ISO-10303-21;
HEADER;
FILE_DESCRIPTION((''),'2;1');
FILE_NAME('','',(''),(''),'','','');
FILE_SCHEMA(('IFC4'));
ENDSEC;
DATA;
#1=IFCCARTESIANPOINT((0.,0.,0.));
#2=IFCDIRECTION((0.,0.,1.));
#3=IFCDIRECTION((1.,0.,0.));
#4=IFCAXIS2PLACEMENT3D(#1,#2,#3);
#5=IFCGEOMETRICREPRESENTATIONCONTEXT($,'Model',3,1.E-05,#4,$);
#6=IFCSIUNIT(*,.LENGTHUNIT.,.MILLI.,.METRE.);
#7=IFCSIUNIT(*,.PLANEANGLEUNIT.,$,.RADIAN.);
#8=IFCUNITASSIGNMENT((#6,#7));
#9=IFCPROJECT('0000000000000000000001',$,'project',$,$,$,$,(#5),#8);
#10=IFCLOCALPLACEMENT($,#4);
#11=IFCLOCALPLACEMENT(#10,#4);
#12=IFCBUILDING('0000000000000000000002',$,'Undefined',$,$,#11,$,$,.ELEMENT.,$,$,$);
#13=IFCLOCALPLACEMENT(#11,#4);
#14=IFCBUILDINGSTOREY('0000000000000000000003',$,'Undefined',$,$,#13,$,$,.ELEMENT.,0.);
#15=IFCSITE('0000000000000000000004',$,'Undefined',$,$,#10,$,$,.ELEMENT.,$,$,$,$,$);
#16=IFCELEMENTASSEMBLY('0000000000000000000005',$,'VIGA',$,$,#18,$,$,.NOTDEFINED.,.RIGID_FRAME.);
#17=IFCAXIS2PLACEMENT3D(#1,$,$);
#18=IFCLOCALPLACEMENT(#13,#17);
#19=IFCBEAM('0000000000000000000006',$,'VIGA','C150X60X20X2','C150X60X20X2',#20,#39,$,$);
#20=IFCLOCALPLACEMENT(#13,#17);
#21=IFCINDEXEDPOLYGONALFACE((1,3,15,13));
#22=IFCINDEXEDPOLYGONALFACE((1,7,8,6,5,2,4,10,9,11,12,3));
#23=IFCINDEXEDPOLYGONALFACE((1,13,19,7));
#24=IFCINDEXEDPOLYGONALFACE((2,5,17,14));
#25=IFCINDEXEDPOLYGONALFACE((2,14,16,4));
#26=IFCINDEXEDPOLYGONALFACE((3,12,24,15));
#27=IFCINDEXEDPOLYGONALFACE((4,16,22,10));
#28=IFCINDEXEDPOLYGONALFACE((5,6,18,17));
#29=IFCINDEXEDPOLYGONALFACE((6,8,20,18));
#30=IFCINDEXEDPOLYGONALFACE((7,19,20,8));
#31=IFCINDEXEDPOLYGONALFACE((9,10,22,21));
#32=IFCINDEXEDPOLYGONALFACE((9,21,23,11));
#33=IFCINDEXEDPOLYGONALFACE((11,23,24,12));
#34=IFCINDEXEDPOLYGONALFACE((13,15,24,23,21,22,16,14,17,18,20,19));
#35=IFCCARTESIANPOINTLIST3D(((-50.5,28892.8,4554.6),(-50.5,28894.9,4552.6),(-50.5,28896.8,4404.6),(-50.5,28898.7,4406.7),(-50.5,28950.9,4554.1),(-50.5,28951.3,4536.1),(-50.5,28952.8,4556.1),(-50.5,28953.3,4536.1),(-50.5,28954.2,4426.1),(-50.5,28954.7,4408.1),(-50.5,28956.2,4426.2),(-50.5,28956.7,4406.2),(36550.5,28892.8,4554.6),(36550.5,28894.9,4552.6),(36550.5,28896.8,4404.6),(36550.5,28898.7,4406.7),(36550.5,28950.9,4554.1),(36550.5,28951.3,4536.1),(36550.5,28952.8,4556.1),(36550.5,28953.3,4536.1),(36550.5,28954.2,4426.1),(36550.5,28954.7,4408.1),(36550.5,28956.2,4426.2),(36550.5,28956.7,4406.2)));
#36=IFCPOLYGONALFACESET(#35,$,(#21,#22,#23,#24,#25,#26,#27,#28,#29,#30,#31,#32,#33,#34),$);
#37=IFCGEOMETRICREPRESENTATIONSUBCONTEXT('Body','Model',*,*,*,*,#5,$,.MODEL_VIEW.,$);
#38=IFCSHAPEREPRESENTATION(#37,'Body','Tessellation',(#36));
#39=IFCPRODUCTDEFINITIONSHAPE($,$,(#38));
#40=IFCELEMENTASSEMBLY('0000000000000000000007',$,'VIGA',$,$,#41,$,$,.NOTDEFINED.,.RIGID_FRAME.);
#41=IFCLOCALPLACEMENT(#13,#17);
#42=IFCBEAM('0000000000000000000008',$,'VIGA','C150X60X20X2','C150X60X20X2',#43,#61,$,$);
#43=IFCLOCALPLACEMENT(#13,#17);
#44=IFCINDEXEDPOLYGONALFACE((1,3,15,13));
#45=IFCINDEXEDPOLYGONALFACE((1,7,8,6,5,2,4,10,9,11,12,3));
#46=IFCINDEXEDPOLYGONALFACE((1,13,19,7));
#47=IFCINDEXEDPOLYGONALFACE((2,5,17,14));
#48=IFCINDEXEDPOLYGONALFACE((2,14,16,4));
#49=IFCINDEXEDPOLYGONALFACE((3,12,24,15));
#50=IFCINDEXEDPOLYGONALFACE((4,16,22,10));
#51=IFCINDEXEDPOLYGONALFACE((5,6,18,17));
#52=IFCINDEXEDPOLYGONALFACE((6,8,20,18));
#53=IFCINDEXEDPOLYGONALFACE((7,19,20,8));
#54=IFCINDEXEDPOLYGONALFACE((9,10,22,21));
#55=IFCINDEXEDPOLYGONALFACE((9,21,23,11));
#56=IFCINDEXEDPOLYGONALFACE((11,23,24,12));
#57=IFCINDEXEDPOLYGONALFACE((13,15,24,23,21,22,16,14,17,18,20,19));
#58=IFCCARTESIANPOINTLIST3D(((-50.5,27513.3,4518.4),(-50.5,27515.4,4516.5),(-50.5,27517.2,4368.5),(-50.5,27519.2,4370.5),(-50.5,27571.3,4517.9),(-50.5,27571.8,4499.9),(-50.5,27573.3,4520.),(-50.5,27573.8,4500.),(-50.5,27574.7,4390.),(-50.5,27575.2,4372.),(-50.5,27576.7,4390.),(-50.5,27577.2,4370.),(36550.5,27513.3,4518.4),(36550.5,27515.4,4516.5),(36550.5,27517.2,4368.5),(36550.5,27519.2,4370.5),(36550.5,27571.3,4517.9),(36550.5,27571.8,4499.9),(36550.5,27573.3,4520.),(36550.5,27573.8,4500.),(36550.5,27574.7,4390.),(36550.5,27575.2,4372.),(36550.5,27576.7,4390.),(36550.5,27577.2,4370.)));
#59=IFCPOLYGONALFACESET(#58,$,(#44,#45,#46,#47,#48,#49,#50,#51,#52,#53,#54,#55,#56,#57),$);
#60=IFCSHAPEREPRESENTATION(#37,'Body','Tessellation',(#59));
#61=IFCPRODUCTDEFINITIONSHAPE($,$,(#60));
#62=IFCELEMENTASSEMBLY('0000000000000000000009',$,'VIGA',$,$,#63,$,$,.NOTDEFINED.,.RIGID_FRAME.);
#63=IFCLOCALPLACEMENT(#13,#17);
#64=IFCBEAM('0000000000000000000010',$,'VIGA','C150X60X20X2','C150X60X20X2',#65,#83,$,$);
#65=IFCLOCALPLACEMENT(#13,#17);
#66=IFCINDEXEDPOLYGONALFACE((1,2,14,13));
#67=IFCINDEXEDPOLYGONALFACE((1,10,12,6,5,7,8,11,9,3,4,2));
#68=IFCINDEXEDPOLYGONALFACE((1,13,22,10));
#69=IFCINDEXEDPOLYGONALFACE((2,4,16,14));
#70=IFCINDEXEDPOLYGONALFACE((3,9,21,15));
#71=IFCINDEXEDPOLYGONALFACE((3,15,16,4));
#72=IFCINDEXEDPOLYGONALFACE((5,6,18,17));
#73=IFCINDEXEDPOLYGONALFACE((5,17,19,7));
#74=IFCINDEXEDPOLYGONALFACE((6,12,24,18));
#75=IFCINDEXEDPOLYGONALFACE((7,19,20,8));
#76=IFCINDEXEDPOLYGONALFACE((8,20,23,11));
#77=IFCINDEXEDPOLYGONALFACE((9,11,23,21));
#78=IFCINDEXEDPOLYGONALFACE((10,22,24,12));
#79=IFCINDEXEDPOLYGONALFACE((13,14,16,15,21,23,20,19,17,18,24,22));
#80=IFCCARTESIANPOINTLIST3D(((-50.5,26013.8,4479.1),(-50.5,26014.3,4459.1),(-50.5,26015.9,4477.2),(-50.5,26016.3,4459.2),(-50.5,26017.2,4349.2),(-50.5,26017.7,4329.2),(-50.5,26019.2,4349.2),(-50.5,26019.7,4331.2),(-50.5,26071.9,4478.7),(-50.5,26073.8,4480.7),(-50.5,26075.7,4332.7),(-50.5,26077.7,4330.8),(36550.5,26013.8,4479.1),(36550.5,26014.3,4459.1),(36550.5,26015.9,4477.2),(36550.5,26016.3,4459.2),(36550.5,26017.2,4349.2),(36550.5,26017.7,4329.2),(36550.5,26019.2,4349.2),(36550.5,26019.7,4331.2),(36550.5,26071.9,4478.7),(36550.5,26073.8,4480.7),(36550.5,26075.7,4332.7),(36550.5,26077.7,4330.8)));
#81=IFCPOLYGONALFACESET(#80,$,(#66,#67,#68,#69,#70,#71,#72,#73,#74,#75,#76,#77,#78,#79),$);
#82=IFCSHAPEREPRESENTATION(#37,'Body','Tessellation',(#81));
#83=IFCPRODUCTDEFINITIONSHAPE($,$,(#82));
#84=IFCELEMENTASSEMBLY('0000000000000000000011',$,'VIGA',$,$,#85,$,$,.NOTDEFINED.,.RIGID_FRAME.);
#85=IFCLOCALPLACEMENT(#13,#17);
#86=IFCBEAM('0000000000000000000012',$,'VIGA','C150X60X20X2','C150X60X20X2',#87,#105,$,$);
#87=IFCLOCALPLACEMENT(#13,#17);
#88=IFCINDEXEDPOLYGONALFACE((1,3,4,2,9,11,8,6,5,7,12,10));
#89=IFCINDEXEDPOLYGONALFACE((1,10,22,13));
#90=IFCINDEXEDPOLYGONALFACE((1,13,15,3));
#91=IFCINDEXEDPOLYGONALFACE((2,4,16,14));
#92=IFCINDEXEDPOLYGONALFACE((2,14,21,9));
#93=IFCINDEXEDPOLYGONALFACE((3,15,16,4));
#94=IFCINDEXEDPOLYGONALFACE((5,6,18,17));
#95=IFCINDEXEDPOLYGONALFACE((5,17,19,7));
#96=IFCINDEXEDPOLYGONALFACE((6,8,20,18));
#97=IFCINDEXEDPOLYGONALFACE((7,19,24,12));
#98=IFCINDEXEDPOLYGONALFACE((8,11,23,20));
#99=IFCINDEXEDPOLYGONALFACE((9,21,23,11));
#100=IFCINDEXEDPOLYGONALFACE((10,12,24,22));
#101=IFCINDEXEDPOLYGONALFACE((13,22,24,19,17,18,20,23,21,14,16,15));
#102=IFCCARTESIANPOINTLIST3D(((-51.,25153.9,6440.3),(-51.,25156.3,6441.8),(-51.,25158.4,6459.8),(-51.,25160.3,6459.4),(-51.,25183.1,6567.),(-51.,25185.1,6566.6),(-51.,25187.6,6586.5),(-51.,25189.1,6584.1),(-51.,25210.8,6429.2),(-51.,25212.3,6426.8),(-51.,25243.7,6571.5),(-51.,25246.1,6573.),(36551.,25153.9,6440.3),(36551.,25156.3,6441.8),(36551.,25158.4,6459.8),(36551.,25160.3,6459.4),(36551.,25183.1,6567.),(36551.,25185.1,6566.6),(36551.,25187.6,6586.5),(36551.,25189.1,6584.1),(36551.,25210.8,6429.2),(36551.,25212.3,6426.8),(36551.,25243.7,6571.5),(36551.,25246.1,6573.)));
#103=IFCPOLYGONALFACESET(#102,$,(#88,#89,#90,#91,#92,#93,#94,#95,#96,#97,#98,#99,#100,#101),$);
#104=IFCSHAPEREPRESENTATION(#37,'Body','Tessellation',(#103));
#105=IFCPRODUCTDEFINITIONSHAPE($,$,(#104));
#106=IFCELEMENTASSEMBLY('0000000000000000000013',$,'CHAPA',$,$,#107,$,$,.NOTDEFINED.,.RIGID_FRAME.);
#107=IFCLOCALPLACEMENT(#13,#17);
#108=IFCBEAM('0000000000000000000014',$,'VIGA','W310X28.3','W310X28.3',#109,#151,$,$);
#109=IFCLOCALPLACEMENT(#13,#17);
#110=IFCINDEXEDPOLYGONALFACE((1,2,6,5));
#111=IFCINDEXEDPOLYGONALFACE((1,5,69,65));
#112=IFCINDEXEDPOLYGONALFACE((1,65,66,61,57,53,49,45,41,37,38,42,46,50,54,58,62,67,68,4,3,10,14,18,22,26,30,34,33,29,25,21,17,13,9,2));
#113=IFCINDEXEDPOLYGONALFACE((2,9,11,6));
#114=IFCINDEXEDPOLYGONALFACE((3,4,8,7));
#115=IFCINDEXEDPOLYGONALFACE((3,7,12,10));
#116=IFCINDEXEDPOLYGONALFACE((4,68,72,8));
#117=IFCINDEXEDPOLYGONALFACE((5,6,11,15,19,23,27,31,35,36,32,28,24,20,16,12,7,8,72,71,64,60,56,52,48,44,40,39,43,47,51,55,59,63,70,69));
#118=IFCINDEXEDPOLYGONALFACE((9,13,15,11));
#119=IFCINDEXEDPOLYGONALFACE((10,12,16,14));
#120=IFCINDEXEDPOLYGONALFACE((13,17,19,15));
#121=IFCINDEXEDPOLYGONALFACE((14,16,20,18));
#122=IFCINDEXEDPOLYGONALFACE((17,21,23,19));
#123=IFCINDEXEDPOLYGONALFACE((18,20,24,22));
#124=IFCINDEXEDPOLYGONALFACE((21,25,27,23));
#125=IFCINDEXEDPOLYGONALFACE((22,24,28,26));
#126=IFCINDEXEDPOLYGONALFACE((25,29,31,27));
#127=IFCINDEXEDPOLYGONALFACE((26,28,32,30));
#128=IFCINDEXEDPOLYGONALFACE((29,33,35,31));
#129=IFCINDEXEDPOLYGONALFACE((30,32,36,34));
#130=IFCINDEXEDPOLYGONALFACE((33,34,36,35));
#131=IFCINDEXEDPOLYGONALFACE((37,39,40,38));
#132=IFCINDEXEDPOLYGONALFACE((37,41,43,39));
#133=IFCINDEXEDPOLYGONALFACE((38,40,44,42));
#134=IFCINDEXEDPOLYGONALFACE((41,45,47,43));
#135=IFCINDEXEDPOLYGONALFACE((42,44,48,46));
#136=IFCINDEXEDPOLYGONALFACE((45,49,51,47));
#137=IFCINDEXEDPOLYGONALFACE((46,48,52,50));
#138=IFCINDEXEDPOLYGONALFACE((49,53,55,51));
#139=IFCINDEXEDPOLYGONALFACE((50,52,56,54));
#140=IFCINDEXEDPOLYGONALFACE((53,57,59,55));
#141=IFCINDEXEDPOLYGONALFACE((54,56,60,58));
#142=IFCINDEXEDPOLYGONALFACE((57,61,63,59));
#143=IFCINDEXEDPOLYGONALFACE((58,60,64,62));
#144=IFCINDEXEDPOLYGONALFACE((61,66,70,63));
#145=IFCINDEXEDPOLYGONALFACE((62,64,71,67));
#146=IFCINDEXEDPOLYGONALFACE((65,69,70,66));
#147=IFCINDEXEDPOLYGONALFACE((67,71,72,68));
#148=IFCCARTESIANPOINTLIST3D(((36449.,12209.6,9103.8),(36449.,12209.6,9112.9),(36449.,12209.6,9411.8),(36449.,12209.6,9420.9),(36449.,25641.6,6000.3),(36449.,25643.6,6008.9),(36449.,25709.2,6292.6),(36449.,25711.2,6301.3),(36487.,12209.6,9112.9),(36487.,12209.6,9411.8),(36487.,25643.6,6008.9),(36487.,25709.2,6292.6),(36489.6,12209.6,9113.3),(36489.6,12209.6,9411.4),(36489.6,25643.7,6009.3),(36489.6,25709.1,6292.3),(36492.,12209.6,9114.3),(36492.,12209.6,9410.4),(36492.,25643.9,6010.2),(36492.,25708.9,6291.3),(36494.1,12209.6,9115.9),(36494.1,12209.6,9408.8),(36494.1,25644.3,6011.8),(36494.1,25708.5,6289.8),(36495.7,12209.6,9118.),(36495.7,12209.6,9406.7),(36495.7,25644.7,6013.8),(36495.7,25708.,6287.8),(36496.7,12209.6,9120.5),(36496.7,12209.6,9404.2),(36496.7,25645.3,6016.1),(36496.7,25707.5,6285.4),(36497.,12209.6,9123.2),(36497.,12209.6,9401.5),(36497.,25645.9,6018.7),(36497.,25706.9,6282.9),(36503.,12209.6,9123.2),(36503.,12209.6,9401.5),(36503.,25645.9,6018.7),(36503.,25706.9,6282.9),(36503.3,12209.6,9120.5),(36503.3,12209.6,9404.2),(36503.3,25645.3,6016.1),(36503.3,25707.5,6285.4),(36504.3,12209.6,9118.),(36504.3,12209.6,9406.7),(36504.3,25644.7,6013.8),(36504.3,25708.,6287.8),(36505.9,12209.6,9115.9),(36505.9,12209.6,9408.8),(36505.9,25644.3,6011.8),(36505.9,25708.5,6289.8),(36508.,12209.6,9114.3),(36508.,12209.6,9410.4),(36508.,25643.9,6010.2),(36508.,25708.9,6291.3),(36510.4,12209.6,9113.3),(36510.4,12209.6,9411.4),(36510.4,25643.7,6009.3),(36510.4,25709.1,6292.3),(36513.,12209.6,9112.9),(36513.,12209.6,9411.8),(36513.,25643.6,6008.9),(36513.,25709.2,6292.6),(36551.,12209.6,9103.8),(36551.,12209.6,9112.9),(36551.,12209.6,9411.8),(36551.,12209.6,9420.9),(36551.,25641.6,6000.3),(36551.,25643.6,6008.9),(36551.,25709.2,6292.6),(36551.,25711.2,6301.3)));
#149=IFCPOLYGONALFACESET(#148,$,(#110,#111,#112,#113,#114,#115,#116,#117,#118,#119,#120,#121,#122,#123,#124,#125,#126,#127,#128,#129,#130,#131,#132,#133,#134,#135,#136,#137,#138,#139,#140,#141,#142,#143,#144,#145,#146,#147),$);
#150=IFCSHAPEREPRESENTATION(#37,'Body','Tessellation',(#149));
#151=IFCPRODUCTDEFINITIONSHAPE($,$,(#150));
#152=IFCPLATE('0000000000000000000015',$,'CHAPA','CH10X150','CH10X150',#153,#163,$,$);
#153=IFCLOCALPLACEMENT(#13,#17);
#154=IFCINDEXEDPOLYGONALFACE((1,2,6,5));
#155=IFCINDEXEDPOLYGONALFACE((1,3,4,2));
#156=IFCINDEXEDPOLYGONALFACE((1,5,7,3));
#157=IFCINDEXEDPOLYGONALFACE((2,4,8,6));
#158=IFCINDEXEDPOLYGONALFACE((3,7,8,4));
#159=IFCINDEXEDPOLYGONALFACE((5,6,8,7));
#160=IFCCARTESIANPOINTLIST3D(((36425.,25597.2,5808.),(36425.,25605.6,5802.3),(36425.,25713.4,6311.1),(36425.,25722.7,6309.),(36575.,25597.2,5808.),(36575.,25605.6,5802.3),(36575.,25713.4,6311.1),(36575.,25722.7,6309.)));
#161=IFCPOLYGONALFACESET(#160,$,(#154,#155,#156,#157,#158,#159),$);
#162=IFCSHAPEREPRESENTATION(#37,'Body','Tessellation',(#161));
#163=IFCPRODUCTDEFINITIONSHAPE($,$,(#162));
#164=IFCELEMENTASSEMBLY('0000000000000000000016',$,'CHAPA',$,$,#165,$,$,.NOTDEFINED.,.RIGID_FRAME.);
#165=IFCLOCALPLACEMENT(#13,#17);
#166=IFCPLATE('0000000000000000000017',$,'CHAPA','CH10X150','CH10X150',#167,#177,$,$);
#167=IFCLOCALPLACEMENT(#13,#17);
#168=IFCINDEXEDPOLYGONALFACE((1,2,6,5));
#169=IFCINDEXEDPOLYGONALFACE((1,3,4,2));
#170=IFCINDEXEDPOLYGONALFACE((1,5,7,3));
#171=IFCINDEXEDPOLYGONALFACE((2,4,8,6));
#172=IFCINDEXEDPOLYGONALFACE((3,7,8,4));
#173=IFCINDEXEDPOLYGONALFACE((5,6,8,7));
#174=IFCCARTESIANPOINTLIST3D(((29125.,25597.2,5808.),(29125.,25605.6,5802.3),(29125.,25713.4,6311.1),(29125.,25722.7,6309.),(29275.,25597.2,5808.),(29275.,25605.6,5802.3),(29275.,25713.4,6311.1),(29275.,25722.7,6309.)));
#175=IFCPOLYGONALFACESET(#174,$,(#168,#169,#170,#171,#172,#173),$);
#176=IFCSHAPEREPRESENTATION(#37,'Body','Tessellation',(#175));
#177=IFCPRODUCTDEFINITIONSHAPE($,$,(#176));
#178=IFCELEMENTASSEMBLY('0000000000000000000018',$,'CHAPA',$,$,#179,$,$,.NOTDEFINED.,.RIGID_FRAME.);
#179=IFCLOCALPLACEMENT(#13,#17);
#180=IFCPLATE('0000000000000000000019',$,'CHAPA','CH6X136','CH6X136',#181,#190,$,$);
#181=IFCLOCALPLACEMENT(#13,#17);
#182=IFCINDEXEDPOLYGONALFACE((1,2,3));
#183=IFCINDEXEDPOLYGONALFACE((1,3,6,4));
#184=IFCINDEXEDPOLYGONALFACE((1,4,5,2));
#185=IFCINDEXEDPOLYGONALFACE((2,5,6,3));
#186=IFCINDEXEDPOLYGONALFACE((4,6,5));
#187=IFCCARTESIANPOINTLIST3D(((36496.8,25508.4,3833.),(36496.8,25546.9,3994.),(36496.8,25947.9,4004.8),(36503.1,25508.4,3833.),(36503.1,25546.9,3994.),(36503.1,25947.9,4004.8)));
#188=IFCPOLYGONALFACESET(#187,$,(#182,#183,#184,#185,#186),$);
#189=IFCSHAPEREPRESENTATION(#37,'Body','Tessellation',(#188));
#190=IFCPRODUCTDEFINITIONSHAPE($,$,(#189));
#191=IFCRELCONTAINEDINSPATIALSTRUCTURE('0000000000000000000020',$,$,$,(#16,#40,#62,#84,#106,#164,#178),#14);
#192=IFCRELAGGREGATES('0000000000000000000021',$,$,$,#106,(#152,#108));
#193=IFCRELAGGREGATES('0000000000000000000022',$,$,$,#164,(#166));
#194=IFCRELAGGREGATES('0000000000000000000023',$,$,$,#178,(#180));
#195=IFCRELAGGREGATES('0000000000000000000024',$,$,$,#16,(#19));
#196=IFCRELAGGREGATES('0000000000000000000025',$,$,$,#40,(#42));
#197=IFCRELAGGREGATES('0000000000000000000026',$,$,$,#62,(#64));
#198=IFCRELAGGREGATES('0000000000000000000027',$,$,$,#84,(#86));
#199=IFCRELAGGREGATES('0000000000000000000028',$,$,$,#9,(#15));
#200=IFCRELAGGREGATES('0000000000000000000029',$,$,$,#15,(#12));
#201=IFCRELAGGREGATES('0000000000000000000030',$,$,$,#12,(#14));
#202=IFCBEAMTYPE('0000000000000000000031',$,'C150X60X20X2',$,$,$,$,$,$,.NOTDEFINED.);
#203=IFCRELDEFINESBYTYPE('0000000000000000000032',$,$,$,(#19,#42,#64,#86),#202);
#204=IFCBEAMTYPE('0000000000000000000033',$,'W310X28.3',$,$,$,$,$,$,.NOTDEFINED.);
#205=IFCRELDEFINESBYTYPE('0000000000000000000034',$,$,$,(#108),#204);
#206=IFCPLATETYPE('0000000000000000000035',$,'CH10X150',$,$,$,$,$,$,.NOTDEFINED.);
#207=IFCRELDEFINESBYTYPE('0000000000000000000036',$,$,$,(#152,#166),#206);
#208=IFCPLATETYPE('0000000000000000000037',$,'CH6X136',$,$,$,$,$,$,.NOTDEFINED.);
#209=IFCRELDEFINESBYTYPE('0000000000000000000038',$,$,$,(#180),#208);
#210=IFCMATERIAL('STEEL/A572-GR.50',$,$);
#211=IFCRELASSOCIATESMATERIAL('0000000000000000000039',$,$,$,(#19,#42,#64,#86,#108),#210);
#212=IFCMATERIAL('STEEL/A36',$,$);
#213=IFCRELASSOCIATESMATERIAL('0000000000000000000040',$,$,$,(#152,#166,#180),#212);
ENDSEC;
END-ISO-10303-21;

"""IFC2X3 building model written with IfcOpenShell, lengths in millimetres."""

from ifc_helpers import new_model, si_unit, frame, origin_with_axes, origin_2d_with_axis, place, context, subcontext, project, spatial, polyline, i_section, c_section, outline, extrude, clip, halfspace, material, type_object, element, aggregate, save


model = new_model("IFC2X3")

# Units and contexts
model_context = context("Model", 3, precision=1e-05, world=origin_with_axes())
body_context = subcontext(model_context, "Body", "Model", "MODEL_VIEW")
ifc_project = project(units=[si_unit("LENGTHUNIT", "METRE", prefix="MILLI"), si_unit("PLANEANGLEUNIT", "RADIAN")], contexts=[model_context])

# Site, building, storey
site_placement = place(None, origin_with_axes())
site = spatial("IfcSite", under=ifc_project, at=site_placement, Name="Undefined", CompositionType="ELEMENT")
building_placement = place(site_placement, origin_with_axes())
building = spatial("IfcBuilding", under=site, at=building_placement, Name="Undefined", CompositionType="ELEMENT")
storey_placement = place(building_placement, origin_with_axes())
storey = spatial("IfcBuildingStorey", under=building, at=storey_placement, Name="Undefined", CompositionType="ELEMENT", Elevation=0.0)

# Element assemblies, beams
ifc_material_1 = material(Name="STEEL/A36")
assembly_1_placement = place(storey_placement, origin_with_axes())
assembly_1 = element("IfcElementAssembly", 1, at=assembly_1_placement, inside=storey, Name="VIGA", AssemblyPlace="NOTDEFINED", PredefinedType="RIGID_FRAME")
ifc_material_2 = material(Name="STEEL/A572-GR.50")
beam_type_1 = type_object("IfcBeamType", Name="C150X60X20X2", PredefinedType="NOTDEFINED")
beam_1_placement = place(assembly_1_placement, frame((36550.5, 28924.8, 4480.4), z_axis=(0.0, -0.026187, 0.999657), x_axis=(-1.0, 0.0, 0.0)))
beam_1 = element("IfcBeam", 2, at=beam_1_placement, type_object=beam_type_1, material=ifc_material_2, Name="VIGA", Description="C150X60X20X2", ObjectType="C150X60X20X2", context=body_context, shape_type="SweptSolid", body=[
    extrude(c_section(Depth=150.0, Width=60.0, WallThickness=2.0, Girth=20.0, at=origin_2d_with_axis()), frame((36601.0, 0.0, 0.0), z_axis=(-1.0, 0.0, 0.0), x_axis=(0.0, -1.0, 0.0)), (0.0, 0.0, 1.0), 36601.0),
])
assembly_2_placement = place(storey_placement, origin_with_axes())
assembly_2 = element("IfcElementAssembly", 3, at=assembly_2_placement, inside=storey, Name="VIGA", AssemblyPlace="NOTDEFINED", PredefinedType="RIGID_FRAME")
beam_2_placement = place(assembly_2_placement, frame((36550.5, 27545.3, 4444.2), z_axis=(0.0, -0.026187, 0.999657), x_axis=(-1.0, 0.0, 0.0)))
beam_2 = element("IfcBeam", 4, at=beam_2_placement, type_object=beam_type_1, material=ifc_material_2, Name="VIGA", Description="C150X60X20X2", ObjectType="C150X60X20X2", context=body_context, shape_type="SweptSolid", body=[
    extrude(c_section(Depth=150.0, Width=60.0, WallThickness=2.0, Girth=20.0, at=origin_2d_with_axis()), frame((36601.0, 0.0, 0.0), z_axis=(-1.0, 0.0, 0.0), x_axis=(0.0, -1.0, 0.0)), (0.0, 0.0, 1.0), 36601.0),
])
assembly_3_placement = place(storey_placement, origin_with_axes())
assembly_3 = element("IfcElementAssembly", 5, at=assembly_3_placement, inside=storey, Name="VIGA", AssemblyPlace="NOTDEFINED", PredefinedType="RIGID_FRAME")
beam_3_placement = place(assembly_3_placement, frame((36550.5, 26045.8, 4404.9), z_axis=(0.0, 0.026187, -0.999657), x_axis=(-1.0, 0.0, 0.0)))
beam_3 = element("IfcBeam", 6, at=beam_3_placement, type_object=beam_type_1, material=ifc_material_2, Name="VIGA", Description="C150X60X20X2", ObjectType="C150X60X20X2", context=body_context, shape_type="SweptSolid", body=[
    extrude(c_section(Depth=150.0, Width=60.0, WallThickness=2.0, Girth=20.0, at=origin_2d_with_axis()), frame((36601.0, 0.0, 0.0), z_axis=(-1.0, 0.0, 0.0), x_axis=(0.0, -1.0, 0.0)), (0.0, 0.0, 1.0), 36601.0),
])
assembly_4_placement = place(storey_placement, origin_with_axes())
assembly_4 = element("IfcElementAssembly", 7, at=assembly_4_placement, inside=storey, Name="VIGA", AssemblyPlace="NOTDEFINED", PredefinedType="RIGID_FRAME")
beam_4_placement = place(assembly_4_placement, frame((36551.0, 25200.0, 6506.7), z_axis=(0.0, -0.225124, -0.97433), x_axis=(-1.0, 0.0, 0.0)))
beam_4 = element("IfcBeam", 8, at=beam_4_placement, type_object=beam_type_1, material=ifc_material_2, Name="VIGA", Description="C150X60X20X2", ObjectType="C150X60X20X2", context=body_context, shape_type="SweptSolid", body=[
    extrude(c_section(Depth=150.0, Width=60.0, WallThickness=2.0, Girth=20.0, at=origin_2d_with_axis()), frame((36602.0, 0.0, 0.0), z_axis=(-1.0, 0.0, 0.0), x_axis=(0.0, -1.0, 0.0)), (0.0, 0.0, 1.0), 36602.0),
])
assembly_5_placement = place(storey_placement, origin_with_axes())
assembly_5 = element("IfcElementAssembly", 9, at=assembly_5_placement, inside=storey, Name="CHAPA", AssemblyPlace="NOTDEFINED", PredefinedType="RIGID_FRAME")
beam_type_2 = type_object("IfcBeamType", Name="W310X28.3", PredefinedType="NOTDEFINED")
beam_5_placement = place(assembly_5_placement, frame((36500.0, 25676.4, 6150.8), z_axis=(0.0, -0.225124, -0.97433), x_axis=(0.0, -0.97433, 0.225124)))
beam_5 = element("IfcBeam", 10, at=beam_5_placement, type_object=beam_type_2, material=ifc_material_2, Name="VIGA", Description="W310X28.3", ObjectType="W310X28.3", context=body_context, shape_type="Clipping", body=[
    clip(extrude(i_section(OverallWidth=102.0, OverallDepth=309.0, WebThickness=6.0, FlangeThickness=8.9, FilletRadius=10.0, at=origin_2d_with_axis()), frame((13995.7, 0.0, 0.0), z_axis=(-1.0, 0.0, 0.0), x_axis=(0.0, -1.0, 0.0)), (0.0, 0.0, 1.0), 13995.7), halfspace(frame((13786.4, 0.0, 152.3), z_axis=(0.97433, 0.0, 0.225124), x_axis=(0.225124, 0.0, -0.97433)), False)),
])

# Plate
plate_type_1 = type_object("IfcPlateType", Name="CH10X150", PredefinedType="NOTDEFINED")
plate_1_placement = place(assembly_5_placement, frame((36575.0, 25718.1, 6310.1), z_axis=(0.0, 0.97433, -0.225124), x_axis=(0.0, -0.225124, -0.97433)))
plate_1 = element("IfcPlate", 11, at=plate_1_placement, type_object=plate_type_1, material=ifc_material_1, Name="CHAPA", Description="CH10X150", ObjectType="CH10X150", context=body_context, shape_type="Clipping", body=[
    clip(extrude(outline(polyline([(0.0, 0.0), (520.0, 0.0), (520.0, 150.0), (0.0, 150.0), (0.0, 0.0)])), frame((0.0, 0.0, -4.8), z_axis=(0.0, 0.0, 1.0), x_axis=(1.0, 0.0, 0.0)), (0.0, 0.0, 1.0), 9.5), halfspace(frame((516.4, -500.0, -4.7), z_axis=(0.934951, 0.0, -0.354778), x_axis=(0.354778, 0.0, 0.934951)), False)),
])
aggregate(assembly_5, [plate_1, beam_5])

# Element assemblies, plates
assembly_6_placement = place(storey_placement, origin_with_axes())
assembly_6 = element("IfcElementAssembly", 12, at=assembly_6_placement, inside=storey, Name="CHAPA", AssemblyPlace="NOTDEFINED", PredefinedType="RIGID_FRAME")
plate_2_placement = place(assembly_6_placement, frame((29275.0, 25718.1, 6310.1), z_axis=(0.0, 0.97433, -0.225124), x_axis=(0.0, -0.225124, -0.97433)))
plate_2 = element("IfcPlate", 13, at=plate_2_placement, type_object=plate_type_1, material=ifc_material_1, Name="CHAPA", Description="CH10X150", ObjectType="CH10X150", context=body_context, shape_type="Clipping", body=[
    clip(extrude(outline(polyline([(0.0, 0.0), (520.0, 0.0), (520.0, 150.0), (0.0, 150.0), (0.0, 0.0)])), frame((0.0, 0.0, -4.8), z_axis=(0.0, 0.0, 1.0), x_axis=(1.0, 0.0, 0.0)), (0.0, 0.0, 1.0), 9.5), halfspace(frame((516.4, -500.0, -4.7), z_axis=(0.934951, 0.0, -0.354778), x_axis=(0.354778, 0.0, 0.934951)), False)),
])
aggregate(assembly_6, [plate_2])
assembly_7_placement = place(storey_placement, origin_with_axes())
assembly_7 = element("IfcElementAssembly", 14, at=assembly_7_placement, inside=storey, Name="CHAPA", AssemblyPlace="NOTDEFINED", PredefinedType="RIGID_FRAME")
plate_type_2 = type_object("IfcPlateType", Name="CH6X136", PredefinedType="NOTDEFINED")
plate_3_placement = place(assembly_7_placement, frame((36500.0, 25546.9, 3994.0), z_axis=(-1.0, 0.0, 0.0), x_axis=(0.0, 0.999636, 0.026972)))
plate_3 = element("IfcPlate", 15, at=plate_3_placement, type_object=plate_type_2, material=ifc_material_1, Name="CHAPA", Description="CH6X136", ObjectType="CH6X136", context=body_context, shape_type="SweptSolid", body=[
    extrude(outline(polyline([(0.0, 0.0), (401.1, 0.0), (-42.8, 159.9), (0.0, 0.0)])), frame((0.0, 0.0, -3.1), z_axis=(0.0, 0.0, 1.0), x_axis=(1.0, 0.0, 0.0)), (0.0, 0.0, 1.0), 6.3),
])
aggregate(assembly_7, [plate_3])

aggregate(assembly_1, [beam_1])
aggregate(assembly_2, [beam_2])
aggregate(assembly_3, [beam_3])
aggregate(assembly_4, [beam_4])

save(model, "model.ifc")
